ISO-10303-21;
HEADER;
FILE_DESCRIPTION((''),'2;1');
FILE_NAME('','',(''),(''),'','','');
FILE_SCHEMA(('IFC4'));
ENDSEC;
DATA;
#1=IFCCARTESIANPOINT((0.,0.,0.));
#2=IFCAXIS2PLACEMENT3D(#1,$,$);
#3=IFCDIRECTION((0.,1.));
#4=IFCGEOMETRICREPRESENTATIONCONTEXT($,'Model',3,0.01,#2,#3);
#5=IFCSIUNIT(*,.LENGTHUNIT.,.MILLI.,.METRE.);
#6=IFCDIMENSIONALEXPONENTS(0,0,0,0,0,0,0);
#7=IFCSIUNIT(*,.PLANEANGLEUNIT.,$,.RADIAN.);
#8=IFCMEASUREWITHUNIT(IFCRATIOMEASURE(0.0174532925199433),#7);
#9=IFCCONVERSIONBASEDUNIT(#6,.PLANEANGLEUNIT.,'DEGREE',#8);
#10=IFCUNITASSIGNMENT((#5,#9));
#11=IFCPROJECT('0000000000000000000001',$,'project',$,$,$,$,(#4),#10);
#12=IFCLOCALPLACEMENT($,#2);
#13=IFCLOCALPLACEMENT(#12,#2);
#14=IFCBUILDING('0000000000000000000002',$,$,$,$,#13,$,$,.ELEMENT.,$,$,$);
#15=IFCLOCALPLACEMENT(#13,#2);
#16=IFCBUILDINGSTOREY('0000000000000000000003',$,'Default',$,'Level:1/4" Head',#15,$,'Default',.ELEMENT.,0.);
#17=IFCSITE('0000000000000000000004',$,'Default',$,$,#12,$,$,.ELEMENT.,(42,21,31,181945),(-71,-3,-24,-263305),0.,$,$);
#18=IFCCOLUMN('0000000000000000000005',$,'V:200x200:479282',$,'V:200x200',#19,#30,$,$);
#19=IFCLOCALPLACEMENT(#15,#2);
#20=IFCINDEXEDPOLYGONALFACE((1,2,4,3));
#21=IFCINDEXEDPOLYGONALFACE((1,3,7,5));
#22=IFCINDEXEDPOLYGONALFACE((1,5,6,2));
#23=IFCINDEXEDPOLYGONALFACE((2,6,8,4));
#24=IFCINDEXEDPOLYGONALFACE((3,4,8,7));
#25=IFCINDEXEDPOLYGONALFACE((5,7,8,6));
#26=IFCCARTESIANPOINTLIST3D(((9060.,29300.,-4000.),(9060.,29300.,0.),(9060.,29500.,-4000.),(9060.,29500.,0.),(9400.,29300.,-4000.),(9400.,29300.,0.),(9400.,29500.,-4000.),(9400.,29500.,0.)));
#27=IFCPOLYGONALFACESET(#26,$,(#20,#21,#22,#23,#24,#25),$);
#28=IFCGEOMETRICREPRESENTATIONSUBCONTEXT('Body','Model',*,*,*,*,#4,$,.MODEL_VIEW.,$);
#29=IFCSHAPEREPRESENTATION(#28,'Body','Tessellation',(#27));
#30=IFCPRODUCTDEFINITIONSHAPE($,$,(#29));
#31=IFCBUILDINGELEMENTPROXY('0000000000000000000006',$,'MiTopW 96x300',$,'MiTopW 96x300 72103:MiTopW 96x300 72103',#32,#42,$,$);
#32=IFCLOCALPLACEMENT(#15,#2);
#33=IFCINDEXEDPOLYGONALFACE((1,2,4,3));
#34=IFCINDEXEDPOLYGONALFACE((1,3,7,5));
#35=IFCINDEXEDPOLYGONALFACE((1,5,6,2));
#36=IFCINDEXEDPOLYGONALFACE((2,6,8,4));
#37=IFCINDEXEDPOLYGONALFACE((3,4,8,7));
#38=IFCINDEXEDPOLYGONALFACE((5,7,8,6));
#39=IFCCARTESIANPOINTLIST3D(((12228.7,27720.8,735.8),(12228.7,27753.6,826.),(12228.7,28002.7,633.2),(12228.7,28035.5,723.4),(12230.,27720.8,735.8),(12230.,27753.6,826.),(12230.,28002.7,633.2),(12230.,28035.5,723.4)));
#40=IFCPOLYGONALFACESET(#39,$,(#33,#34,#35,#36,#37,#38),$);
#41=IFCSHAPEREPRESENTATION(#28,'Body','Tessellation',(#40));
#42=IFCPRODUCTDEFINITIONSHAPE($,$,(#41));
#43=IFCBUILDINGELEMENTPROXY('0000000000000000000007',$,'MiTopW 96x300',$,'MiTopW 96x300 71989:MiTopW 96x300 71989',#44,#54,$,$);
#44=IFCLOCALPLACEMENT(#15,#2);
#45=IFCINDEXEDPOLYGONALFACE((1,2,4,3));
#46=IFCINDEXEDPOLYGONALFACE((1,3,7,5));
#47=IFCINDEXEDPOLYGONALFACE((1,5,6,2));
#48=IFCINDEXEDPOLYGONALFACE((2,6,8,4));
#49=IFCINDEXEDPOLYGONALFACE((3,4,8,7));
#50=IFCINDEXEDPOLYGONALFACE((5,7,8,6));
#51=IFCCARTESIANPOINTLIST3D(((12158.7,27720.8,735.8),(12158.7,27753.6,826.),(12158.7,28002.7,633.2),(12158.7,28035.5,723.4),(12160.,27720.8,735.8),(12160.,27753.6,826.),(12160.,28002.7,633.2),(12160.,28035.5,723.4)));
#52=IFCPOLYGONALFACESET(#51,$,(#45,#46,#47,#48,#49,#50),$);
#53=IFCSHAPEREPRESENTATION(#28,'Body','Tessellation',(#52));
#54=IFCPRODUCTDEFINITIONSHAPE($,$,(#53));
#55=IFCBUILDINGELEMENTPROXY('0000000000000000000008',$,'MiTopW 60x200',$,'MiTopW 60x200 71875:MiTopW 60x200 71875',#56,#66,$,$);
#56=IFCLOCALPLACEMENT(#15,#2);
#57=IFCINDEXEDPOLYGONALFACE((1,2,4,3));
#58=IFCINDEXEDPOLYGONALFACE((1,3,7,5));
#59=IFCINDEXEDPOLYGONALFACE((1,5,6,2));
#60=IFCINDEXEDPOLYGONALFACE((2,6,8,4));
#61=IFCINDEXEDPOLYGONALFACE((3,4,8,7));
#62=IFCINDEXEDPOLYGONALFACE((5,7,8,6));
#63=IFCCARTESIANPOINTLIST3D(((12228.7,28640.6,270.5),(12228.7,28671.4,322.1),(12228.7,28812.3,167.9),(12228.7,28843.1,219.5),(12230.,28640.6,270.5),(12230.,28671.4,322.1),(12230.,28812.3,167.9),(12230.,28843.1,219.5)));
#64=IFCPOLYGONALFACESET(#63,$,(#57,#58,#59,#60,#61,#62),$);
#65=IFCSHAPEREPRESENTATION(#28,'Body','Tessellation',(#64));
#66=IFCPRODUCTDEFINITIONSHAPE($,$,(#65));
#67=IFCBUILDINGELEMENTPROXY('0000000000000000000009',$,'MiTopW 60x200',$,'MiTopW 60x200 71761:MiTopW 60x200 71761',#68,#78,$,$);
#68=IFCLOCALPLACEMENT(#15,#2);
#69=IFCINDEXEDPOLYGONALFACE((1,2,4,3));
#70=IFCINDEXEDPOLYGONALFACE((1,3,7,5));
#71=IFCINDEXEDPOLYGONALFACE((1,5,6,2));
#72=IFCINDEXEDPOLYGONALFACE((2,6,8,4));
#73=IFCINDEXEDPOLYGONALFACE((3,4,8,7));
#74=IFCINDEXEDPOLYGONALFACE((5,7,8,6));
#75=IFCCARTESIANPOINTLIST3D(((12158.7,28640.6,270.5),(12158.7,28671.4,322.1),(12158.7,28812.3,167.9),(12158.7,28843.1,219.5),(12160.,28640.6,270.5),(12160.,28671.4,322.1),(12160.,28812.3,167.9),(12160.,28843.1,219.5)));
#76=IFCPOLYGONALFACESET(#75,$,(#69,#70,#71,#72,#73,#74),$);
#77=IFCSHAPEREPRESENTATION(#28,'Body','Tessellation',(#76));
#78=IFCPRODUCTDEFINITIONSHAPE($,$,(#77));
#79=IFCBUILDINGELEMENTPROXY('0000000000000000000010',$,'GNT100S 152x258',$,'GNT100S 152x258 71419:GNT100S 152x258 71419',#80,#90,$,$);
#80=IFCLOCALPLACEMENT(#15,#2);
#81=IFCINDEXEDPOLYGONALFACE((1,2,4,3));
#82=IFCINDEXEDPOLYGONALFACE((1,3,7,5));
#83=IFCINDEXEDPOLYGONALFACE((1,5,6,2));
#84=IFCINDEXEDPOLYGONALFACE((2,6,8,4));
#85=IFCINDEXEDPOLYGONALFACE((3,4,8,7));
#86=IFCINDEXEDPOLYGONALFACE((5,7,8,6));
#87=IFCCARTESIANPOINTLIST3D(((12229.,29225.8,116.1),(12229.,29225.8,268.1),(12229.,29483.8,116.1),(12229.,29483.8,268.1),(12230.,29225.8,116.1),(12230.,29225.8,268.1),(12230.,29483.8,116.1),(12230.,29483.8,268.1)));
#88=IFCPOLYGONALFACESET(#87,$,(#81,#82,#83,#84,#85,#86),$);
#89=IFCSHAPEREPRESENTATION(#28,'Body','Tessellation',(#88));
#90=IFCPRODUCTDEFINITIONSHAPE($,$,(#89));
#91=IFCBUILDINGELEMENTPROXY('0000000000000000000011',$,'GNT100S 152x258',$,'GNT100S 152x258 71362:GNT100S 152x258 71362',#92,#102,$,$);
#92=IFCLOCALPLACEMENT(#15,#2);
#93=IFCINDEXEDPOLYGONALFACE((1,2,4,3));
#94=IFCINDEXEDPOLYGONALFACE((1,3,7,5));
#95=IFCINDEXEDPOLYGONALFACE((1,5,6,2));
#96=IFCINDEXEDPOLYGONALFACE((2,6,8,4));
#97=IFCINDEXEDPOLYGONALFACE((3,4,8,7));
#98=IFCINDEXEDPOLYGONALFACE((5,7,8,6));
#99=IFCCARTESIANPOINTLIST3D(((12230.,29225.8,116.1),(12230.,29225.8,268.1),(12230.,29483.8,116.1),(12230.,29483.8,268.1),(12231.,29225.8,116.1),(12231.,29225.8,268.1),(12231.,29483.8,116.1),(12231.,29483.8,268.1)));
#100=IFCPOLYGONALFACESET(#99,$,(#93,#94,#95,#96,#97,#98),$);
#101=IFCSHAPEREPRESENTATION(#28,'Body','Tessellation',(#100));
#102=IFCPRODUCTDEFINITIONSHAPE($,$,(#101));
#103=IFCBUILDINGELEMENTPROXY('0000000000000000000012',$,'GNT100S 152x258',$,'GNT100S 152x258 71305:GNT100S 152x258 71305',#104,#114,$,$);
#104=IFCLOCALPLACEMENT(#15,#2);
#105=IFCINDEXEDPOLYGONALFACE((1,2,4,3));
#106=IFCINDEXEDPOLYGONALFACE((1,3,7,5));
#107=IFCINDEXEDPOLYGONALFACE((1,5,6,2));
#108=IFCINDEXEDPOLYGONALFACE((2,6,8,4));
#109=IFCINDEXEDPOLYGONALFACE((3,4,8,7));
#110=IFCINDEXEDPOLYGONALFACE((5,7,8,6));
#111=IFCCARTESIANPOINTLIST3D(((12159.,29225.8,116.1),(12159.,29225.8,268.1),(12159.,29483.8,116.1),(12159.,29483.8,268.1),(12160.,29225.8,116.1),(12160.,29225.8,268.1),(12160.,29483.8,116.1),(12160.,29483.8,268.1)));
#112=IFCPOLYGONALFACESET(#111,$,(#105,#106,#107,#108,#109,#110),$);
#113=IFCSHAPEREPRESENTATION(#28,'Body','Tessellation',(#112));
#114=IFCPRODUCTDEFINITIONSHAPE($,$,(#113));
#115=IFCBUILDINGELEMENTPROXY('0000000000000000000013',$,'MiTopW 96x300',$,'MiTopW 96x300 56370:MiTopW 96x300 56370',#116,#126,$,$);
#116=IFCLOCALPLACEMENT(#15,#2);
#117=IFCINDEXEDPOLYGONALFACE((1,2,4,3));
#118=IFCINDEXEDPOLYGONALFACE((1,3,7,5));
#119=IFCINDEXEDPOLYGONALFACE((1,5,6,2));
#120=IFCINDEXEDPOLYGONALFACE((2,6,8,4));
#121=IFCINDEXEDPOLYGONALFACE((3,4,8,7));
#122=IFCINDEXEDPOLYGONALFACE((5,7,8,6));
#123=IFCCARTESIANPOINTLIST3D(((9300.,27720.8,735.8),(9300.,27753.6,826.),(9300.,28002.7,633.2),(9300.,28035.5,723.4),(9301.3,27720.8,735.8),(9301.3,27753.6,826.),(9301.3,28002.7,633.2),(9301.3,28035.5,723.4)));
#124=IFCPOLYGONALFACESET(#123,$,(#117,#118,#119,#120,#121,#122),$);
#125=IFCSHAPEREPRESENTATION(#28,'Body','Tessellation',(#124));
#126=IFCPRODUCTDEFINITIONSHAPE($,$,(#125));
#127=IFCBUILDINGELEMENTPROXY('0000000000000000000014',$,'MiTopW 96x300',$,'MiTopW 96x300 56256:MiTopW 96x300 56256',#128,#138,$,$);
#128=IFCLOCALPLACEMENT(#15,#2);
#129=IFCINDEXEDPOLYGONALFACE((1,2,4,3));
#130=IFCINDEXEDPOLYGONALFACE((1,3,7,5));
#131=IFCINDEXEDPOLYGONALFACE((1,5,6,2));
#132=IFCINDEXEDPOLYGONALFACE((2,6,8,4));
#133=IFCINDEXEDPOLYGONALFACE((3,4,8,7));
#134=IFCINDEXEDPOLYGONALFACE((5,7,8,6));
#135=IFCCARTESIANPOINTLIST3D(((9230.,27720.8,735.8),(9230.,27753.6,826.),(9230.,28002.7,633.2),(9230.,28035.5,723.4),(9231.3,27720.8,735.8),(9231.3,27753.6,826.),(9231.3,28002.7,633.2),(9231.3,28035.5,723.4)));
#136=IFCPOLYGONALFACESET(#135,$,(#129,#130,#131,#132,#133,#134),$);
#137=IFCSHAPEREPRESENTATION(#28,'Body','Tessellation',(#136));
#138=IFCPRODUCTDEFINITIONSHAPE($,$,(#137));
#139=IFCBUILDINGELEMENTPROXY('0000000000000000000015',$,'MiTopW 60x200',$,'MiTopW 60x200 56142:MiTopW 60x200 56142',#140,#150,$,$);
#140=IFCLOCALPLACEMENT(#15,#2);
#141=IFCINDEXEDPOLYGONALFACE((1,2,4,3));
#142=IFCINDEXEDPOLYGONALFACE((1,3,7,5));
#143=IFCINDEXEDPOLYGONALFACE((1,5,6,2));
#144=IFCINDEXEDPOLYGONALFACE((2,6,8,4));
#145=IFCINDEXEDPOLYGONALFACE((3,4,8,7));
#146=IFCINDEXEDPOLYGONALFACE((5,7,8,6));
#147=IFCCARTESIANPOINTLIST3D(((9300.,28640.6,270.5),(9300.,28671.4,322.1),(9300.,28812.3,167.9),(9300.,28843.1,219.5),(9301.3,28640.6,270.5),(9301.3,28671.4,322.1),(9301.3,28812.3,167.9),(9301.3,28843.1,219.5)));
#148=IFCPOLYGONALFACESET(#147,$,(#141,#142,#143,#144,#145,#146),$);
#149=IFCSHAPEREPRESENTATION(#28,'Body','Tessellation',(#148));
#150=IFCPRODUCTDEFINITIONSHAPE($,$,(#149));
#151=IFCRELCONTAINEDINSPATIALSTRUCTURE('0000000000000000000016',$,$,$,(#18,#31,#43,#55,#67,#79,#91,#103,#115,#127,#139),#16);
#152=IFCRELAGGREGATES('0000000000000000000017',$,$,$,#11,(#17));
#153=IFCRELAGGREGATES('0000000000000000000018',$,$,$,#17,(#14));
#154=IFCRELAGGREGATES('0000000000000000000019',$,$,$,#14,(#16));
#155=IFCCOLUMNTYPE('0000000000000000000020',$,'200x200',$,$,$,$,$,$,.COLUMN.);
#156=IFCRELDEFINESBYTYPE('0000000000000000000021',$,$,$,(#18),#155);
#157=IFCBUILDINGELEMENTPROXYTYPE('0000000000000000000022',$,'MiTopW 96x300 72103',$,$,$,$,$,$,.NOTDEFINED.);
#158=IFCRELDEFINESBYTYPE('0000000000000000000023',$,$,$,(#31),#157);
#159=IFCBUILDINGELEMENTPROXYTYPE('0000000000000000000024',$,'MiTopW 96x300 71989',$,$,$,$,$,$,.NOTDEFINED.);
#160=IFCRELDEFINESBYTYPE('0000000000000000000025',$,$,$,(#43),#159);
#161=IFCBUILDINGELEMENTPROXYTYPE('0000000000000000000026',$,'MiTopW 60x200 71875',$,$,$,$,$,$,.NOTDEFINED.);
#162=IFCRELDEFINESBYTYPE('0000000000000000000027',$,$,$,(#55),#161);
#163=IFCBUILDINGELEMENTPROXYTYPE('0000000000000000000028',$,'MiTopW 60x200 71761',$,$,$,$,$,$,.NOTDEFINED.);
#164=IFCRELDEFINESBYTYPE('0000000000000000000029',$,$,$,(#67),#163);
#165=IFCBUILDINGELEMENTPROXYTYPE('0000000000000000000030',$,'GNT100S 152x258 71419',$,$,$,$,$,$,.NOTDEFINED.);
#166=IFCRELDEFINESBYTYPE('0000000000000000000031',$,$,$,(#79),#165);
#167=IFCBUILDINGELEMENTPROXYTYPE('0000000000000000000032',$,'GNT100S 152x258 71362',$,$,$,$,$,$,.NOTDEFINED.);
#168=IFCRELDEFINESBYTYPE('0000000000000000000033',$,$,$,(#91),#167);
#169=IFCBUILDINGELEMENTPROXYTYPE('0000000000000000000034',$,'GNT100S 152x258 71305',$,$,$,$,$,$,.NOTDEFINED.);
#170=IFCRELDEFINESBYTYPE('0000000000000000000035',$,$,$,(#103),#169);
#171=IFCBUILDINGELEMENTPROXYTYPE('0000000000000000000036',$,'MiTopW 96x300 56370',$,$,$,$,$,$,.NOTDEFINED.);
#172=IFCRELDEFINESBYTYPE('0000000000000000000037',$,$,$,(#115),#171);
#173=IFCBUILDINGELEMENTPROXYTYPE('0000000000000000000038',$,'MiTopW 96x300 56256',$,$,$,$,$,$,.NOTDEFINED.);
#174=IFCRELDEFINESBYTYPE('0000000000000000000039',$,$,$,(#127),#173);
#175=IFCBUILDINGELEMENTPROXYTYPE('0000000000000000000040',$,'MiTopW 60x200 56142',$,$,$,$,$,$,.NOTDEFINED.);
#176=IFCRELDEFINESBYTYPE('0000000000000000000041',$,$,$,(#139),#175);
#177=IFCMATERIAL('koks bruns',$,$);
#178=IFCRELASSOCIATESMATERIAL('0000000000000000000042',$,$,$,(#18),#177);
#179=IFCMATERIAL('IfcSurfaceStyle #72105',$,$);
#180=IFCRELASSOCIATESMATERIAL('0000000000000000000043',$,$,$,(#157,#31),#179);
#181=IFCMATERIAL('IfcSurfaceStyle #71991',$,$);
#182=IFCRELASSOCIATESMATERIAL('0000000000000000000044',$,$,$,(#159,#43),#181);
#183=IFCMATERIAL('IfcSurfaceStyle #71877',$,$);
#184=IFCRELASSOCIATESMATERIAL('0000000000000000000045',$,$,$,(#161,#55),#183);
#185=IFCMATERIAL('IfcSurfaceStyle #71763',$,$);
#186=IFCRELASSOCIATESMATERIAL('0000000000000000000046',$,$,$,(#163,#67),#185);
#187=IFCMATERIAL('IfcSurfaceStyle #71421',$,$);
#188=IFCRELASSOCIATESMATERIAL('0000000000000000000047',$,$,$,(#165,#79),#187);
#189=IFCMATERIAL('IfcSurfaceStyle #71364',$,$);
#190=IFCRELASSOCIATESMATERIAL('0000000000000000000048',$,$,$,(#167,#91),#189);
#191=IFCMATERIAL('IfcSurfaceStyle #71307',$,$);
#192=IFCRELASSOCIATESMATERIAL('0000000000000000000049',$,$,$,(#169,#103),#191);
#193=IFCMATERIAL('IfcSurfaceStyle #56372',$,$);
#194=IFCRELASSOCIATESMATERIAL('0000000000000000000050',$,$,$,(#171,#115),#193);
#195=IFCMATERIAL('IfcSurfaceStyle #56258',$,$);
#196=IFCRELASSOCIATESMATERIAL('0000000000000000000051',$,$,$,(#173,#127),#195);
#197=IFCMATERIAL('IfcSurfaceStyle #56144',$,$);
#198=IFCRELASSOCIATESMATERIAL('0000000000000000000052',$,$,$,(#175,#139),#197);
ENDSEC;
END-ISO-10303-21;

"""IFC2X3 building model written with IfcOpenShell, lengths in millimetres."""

from ifc_helpers import new_model, entity, si_unit, converted_unit, direction, frame, origin, origin_2d_with_axis, place, context, subcontext, project, spatial, polyline, rectangle, outline, extrude, source, transform, mapped, material, type_object, type_shapes, element, save


model = new_model("IFC2X3")

# Units and contexts
model_context = context("Model", 3, precision=0.01, world=origin(), true_north=direction((0.0, 1.0)))
body_context = subcontext(model_context, "Body", "Model", "MODEL_VIEW")
ifc_project = project(units=[si_unit("LENGTHUNIT", "METRE", prefix="MILLI"), converted_unit("PLANEANGLEUNIT", "DEGREE", entity("IfcRatioMeasure", 0.0174532925199433), si_unit("PLANEANGLEUNIT", "RADIAN"), dimensions=[0, 0, 0, 0, 0, 0, 0])], contexts=[model_context])

# Site, building, storey
site_placement = place(None, origin())
site = spatial("IfcSite", under=ifc_project, at=site_placement, Name="Default", CompositionType="ELEMENT", RefLatitude=(42, 21, 31, 181945), RefLongitude=(-71, -3, -24, -263305), RefElevation=0.0)
building_placement = place(site_placement, origin())
building = spatial("IfcBuilding", under=site, at=building_placement, CompositionType="ELEMENT")
storey_placement = place(building_placement, origin())
storey = spatial("IfcBuildingStorey", under=building, at=storey_placement, Name="Default", ObjectType="Level:1/4\" Head", LongName="Default", CompositionType="ELEMENT", Elevation=0.0)

# Column
ifc_material_1 = material(Name="koks bruns")
column_type_1 = type_object("IfcColumnType", Name="200x200", PredefinedType="COLUMN")
shared_shape_1 = source(origin(), body_context, "Body", "SweptSolid", [
    extrude(rectangle(XDim=340.0, YDim=200.0, at=origin_2d_with_axis()), frame((100.0, 280.0, -4000.0), z_axis=(0.0, 0.0, 1.0), x_axis=(0.0, -1.0, 0.0)), (0.0, 0.0, 1.0), 4000.0),
])
type_shapes(column_type_1, [shared_shape_1])
column_placement = place(storey_placement, frame((9510.0, 29300.0, 0.0), z_axis=(0.0, 0.0, 1.0), x_axis=(0.0, 1.0, 0.0)))
element("IfcColumn", 1, at=column_placement, inside=storey, type_object=column_type_1, material=ifc_material_1, Name="V:200x200:479282", ObjectType="V:200x200", context=body_context, shape_type="MappedRepresentation", body=[
    mapped(shared_shape_1, transform((0.0, 0.0, 0.0), scale=1.0)),
])

# Building element proxies
ifc_material_2 = material(Name="IfcSurfaceStyle #72105")
building_element_proxy_type_1 = type_object("IfcBuildingElementProxyType", Name="MiTopW 96x300 72103", PredefinedType="NOTDEFINED", material=ifc_material_2)
shared_shape_2 = source(origin(), body_context, "Body", "SweptSolid", [
    extrude(outline(polyline([(-150.0, -48.0), (150.0, -48.0), (150.0, 48.0), (-150.0, 48.0), (-150.0, -48.0)])), frame((150.0, 48.0, 0.0), z_axis=(0.0, 0.0, 1.0), x_axis=(-1.0, 0.0, 0.0)), (0.0, 0.0, 1.0), 1.3),
])
type_shapes(building_element_proxy_type_1, [shared_shape_2])
proxy_1_placement = place(building_placement, frame((12230.0, 28002.7, 633.2), z_axis=(-1.0, 0.0, 0.0), x_axis=(0.0, -0.939693, 0.34202)))
element("IfcBuildingElementProxy", 2, at=proxy_1_placement, inside=storey, type_object=building_element_proxy_type_1, material=ifc_material_2, Name="MiTopW 96x300", ObjectType="MiTopW 96x300 72103:MiTopW 96x300 72103", context=body_context, shape_type="MappedRepresentation", body=[
    mapped(shared_shape_2, transform((0.0, 0.0, 0.0), scale=1.0)),
])
ifc_material_3 = material(Name="IfcSurfaceStyle #71991")
building_element_proxy_type_2 = type_object("IfcBuildingElementProxyType", Name="MiTopW 96x300 71989", PredefinedType="NOTDEFINED", material=ifc_material_3)
shared_shape_3 = source(origin(), body_context, "Body", "SweptSolid", [
    extrude(outline(polyline([(-150.0, -48.0), (150.0, -48.0), (150.0, 48.0), (-150.0, 48.0), (-150.0, -48.0)])), frame((150.0, 48.0, 0.0), z_axis=(0.0, 0.0, 1.0), x_axis=(-1.0, 0.0, 0.0)), (0.0, 0.0, 1.0), 1.3),
])
type_shapes(building_element_proxy_type_2, [shared_shape_3])
proxy_2_placement = place(building_placement, frame((12160.0, 28002.7, 633.2), z_axis=(-1.0, 0.0, 0.0), x_axis=(0.0, -0.939693, 0.34202)))
element("IfcBuildingElementProxy", 3, at=proxy_2_placement, inside=storey, type_object=building_element_proxy_type_2, material=ifc_material_3, Name="MiTopW 96x300", ObjectType="MiTopW 96x300 71989:MiTopW 96x300 71989", context=body_context, shape_type="MappedRepresentation", body=[
    mapped(shared_shape_3, transform((0.0, 0.0, 0.0), scale=1.0)),
])
ifc_material_4 = material(Name="IfcSurfaceStyle #71877")
building_element_proxy_type_3 = type_object("IfcBuildingElementProxyType", Name="MiTopW 60x200 71875", PredefinedType="NOTDEFINED", material=ifc_material_4)
shared_shape_4 = source(origin(), body_context, "Body", "SweptSolid", [
    extrude(outline(polyline([(-100.0, -30.0), (100.0, -30.0), (100.0, 30.0), (-100.0, 30.0), (-100.0, -30.0)])), frame((100.0, 30.0, 0.0), z_axis=(0.0, 0.0, 1.0), x_axis=(-1.0, 0.0, 0.0)), (0.0, 0.0, 1.0), 1.3),
])
type_shapes(building_element_proxy_type_3, [shared_shape_4])
proxy_3_placement = place(building_placement, frame((12230.0, 28812.3, 167.9), z_axis=(-1.0, 0.0, 0.0), x_axis=(0.0, -0.858392, 0.512994)))
element("IfcBuildingElementProxy", 4, at=proxy_3_placement, inside=storey, type_object=building_element_proxy_type_3, material=ifc_material_4, Name="MiTopW 60x200", ObjectType="MiTopW 60x200 71875:MiTopW 60x200 71875", context=body_context, shape_type="MappedRepresentation", body=[
    mapped(shared_shape_4, transform((0.0, 0.0, 0.0), scale=1.0)),
])
ifc_material_5 = material(Name="IfcSurfaceStyle #71763")
building_element_proxy_type_4 = type_object("IfcBuildingElementProxyType", Name="MiTopW 60x200 71761", PredefinedType="NOTDEFINED", material=ifc_material_5)
shared_shape_5 = source(origin(), body_context, "Body", "SweptSolid", [
    extrude(outline(polyline([(-100.0, -30.0), (100.0, -30.0), (100.0, 30.0), (-100.0, 30.0), (-100.0, -30.0)])), frame((100.0, 30.0, 0.0), z_axis=(0.0, 0.0, 1.0), x_axis=(-1.0, 0.0, 0.0)), (0.0, 0.0, 1.0), 1.3),
])
type_shapes(building_element_proxy_type_4, [shared_shape_5])
proxy_4_placement = place(building_placement, frame((12160.0, 28812.3, 167.9), z_axis=(-1.0, 0.0, 0.0), x_axis=(0.0, -0.858392, 0.512994)))
element("IfcBuildingElementProxy", 5, at=proxy_4_placement, inside=storey, type_object=building_element_proxy_type_4, material=ifc_material_5, Name="MiTopW 60x200", ObjectType="MiTopW 60x200 71761:MiTopW 60x200 71761", context=body_context, shape_type="MappedRepresentation", body=[
    mapped(shared_shape_5, transform((0.0, 0.0, 0.0), scale=1.0)),
])
ifc_material_6 = material(Name="IfcSurfaceStyle #71421")
building_element_proxy_type_5 = type_object("IfcBuildingElementProxyType", Name="GNT100S 152x258 71419", PredefinedType="NOTDEFINED", material=ifc_material_6)
shared_shape_6 = source(origin(), body_context, "Body", "SweptSolid", [
    extrude(rectangle(XDim=258.0, YDim=152.0, at=origin_2d_with_axis()), frame((129.0, 76.0, 0.0), z_axis=(0.0, 0.0, 1.0), x_axis=(-1.0, 0.0, 0.0)), (0.0, 0.0, 1.0), 1.0),
])
type_shapes(building_element_proxy_type_5, [shared_shape_6])
proxy_5_placement = place(building_placement, frame((12230.0, 29483.8, 116.1), z_axis=(-1.0, 0.0, 0.0), x_axis=(0.0, -1.0, 0.0)))
element("IfcBuildingElementProxy", 6, at=proxy_5_placement, inside=storey, type_object=building_element_proxy_type_5, material=ifc_material_6, Name="GNT100S 152x258", ObjectType="GNT100S 152x258 71419:GNT100S 152x258 71419", context=body_context, shape_type="MappedRepresentation", body=[
    mapped(shared_shape_6, transform((0.0, 0.0, 0.0), scale=1.0)),
])
ifc_material_7 = material(Name="IfcSurfaceStyle #71364")
building_element_proxy_type_6 = type_object("IfcBuildingElementProxyType", Name="GNT100S 152x258 71362", PredefinedType="NOTDEFINED", material=ifc_material_7)
shared_shape_7 = source(origin(), body_context, "Body", "SweptSolid", [
    extrude(rectangle(XDim=258.0, YDim=152.0, at=origin_2d_with_axis()), frame((129.0, 76.0, 0.0), z_axis=(0.0, 0.0, 1.0), x_axis=(-1.0, 0.0, 0.0)), (0.0, 0.0, 1.0), 1.0),
])
type_shapes(building_element_proxy_type_6, [shared_shape_7])
proxy_6_placement = place(building_placement, frame((12231.0, 29483.8, 116.1), z_axis=(-1.0, 0.0, 0.0), x_axis=(0.0, -1.0, 0.0)))
element("IfcBuildingElementProxy", 7, at=proxy_6_placement, inside=storey, type_object=building_element_proxy_type_6, material=ifc_material_7, Name="GNT100S 152x258", ObjectType="GNT100S 152x258 71362:GNT100S 152x258 71362", context=body_context, shape_type="MappedRepresentation", body=[
    mapped(shared_shape_7, transform((0.0, 0.0, 0.0), scale=1.0)),
])
ifc_material_8 = material(Name="IfcSurfaceStyle #71307")
building_element_proxy_type_7 = type_object("IfcBuildingElementProxyType", Name="GNT100S 152x258 71305", PredefinedType="NOTDEFINED", material=ifc_material_8)
shared_shape_8 = source(origin(), body_context, "Body", "SweptSolid", [
    extrude(rectangle(XDim=258.0, YDim=152.0, at=origin_2d_with_axis()), frame((129.0, 76.0, 0.0), z_axis=(0.0, 0.0, 1.0), x_axis=(-1.0, 0.0, 0.0)), (0.0, 0.0, 1.0), 1.0),
])
type_shapes(building_element_proxy_type_7, [shared_shape_8])
proxy_7_placement = place(building_placement, frame((12160.0, 29483.8, 116.1), z_axis=(-1.0, 0.0, 0.0), x_axis=(0.0, -1.0, 0.0)))
element("IfcBuildingElementProxy", 8, at=proxy_7_placement, inside=storey, type_object=building_element_proxy_type_7, material=ifc_material_8, Name="GNT100S 152x258", ObjectType="GNT100S 152x258 71305:GNT100S 152x258 71305", context=body_context, shape_type="MappedRepresentation", body=[
    mapped(shared_shape_8, transform((0.0, 0.0, 0.0), scale=1.0)),
])
ifc_material_9 = material(Name="IfcSurfaceStyle #56372")
building_element_proxy_type_8 = type_object("IfcBuildingElementProxyType", Name="MiTopW 96x300 56370", PredefinedType="NOTDEFINED", material=ifc_material_9)
shared_shape_9 = source(origin(), body_context, "Body", "SweptSolid", [
    extrude(outline(polyline([(-150.0, -48.0), (150.0, -48.0), (150.0, 48.0), (-150.0, 48.0), (-150.0, -48.0)])), frame((150.0, 48.0, 0.0), z_axis=(0.0, 0.0, 1.0), x_axis=(-1.0, 0.0, 0.0)), (0.0, 0.0, 1.0), 1.3),
])
type_shapes(building_element_proxy_type_8, [shared_shape_9])
proxy_8_placement = place(building_placement, frame((9301.3, 28002.7, 633.2), z_axis=(-1.0, 0.0, 0.0), x_axis=(0.0, -0.939693, 0.34202)))
element("IfcBuildingElementProxy", 9, at=proxy_8_placement, inside=storey, type_object=building_element_proxy_type_8, material=ifc_material_9, Name="MiTopW 96x300", ObjectType="MiTopW 96x300 56370:MiTopW 96x300 56370", context=body_context, shape_type="MappedRepresentation", body=[
    mapped(shared_shape_9, transform((0.0, 0.0, 0.0), scale=1.0)),
])
ifc_material_10 = material(Name="IfcSurfaceStyle #56258")
building_element_proxy_type_9 = type_object("IfcBuildingElementProxyType", Name="MiTopW 96x300 56256", PredefinedType="NOTDEFINED", material=ifc_material_10)
shared_shape_10 = source(origin(), body_context, "Body", "SweptSolid", [
    extrude(outline(polyline([(-150.0, -48.0), (150.0, -48.0), (150.0, 48.0), (-150.0, 48.0), (-150.0, -48.0)])), frame((150.0, 48.0, 0.0), z_axis=(0.0, 0.0, 1.0), x_axis=(-1.0, 0.0, 0.0)), (0.0, 0.0, 1.0), 1.3),
])
type_shapes(building_element_proxy_type_9, [shared_shape_10])
proxy_9_placement = place(building_placement, frame((9231.3, 28002.7, 633.2), z_axis=(-1.0, 0.0, 0.0), x_axis=(0.0, -0.939693, 0.34202)))
element("IfcBuildingElementProxy", 10, at=proxy_9_placement, inside=storey, type_object=building_element_proxy_type_9, material=ifc_material_10, Name="MiTopW 96x300", ObjectType="MiTopW 96x300 56256:MiTopW 96x300 56256", context=body_context, shape_type="MappedRepresentation", body=[
    mapped(shared_shape_10, transform((0.0, 0.0, 0.0), scale=1.0)),
])
ifc_material_11 = material(Name="IfcSurfaceStyle #56144")
building_element_proxy_type_10 = type_object("IfcBuildingElementProxyType", Name="MiTopW 60x200 56142", PredefinedType="NOTDEFINED", material=ifc_material_11)
shared_shape_11 = source(origin(), body_context, "Body", "SweptSolid", [
    extrude(outline(polyline([(-100.0, -30.0), (100.0, -30.0), (100.0, 30.0), (-100.0, 30.0), (-100.0, -30.0)])), frame((100.0, 30.0, 0.0), z_axis=(0.0, 0.0, 1.0), x_axis=(-1.0, 0.0, 0.0)), (0.0, 0.0, 1.0), 1.3),
])
type_shapes(building_element_proxy_type_10, [shared_shape_11])
proxy_10_placement = place(building_placement, frame((9301.3, 28812.3, 167.9), z_axis=(-1.0, 0.0, 0.0), x_axis=(0.0, -0.858392, 0.512994)))
element("IfcBuildingElementProxy", 11, at=proxy_10_placement, inside=storey, type_object=building_element_proxy_type_10, material=ifc_material_11, Name="MiTopW 60x200", ObjectType="MiTopW 60x200 56142:MiTopW 60x200 56142", context=body_context, shape_type="MappedRepresentation", body=[
    mapped(shared_shape_11, transform((0.0, 0.0, 0.0), scale=1.0)),
])

save(model, "model.ifc")
